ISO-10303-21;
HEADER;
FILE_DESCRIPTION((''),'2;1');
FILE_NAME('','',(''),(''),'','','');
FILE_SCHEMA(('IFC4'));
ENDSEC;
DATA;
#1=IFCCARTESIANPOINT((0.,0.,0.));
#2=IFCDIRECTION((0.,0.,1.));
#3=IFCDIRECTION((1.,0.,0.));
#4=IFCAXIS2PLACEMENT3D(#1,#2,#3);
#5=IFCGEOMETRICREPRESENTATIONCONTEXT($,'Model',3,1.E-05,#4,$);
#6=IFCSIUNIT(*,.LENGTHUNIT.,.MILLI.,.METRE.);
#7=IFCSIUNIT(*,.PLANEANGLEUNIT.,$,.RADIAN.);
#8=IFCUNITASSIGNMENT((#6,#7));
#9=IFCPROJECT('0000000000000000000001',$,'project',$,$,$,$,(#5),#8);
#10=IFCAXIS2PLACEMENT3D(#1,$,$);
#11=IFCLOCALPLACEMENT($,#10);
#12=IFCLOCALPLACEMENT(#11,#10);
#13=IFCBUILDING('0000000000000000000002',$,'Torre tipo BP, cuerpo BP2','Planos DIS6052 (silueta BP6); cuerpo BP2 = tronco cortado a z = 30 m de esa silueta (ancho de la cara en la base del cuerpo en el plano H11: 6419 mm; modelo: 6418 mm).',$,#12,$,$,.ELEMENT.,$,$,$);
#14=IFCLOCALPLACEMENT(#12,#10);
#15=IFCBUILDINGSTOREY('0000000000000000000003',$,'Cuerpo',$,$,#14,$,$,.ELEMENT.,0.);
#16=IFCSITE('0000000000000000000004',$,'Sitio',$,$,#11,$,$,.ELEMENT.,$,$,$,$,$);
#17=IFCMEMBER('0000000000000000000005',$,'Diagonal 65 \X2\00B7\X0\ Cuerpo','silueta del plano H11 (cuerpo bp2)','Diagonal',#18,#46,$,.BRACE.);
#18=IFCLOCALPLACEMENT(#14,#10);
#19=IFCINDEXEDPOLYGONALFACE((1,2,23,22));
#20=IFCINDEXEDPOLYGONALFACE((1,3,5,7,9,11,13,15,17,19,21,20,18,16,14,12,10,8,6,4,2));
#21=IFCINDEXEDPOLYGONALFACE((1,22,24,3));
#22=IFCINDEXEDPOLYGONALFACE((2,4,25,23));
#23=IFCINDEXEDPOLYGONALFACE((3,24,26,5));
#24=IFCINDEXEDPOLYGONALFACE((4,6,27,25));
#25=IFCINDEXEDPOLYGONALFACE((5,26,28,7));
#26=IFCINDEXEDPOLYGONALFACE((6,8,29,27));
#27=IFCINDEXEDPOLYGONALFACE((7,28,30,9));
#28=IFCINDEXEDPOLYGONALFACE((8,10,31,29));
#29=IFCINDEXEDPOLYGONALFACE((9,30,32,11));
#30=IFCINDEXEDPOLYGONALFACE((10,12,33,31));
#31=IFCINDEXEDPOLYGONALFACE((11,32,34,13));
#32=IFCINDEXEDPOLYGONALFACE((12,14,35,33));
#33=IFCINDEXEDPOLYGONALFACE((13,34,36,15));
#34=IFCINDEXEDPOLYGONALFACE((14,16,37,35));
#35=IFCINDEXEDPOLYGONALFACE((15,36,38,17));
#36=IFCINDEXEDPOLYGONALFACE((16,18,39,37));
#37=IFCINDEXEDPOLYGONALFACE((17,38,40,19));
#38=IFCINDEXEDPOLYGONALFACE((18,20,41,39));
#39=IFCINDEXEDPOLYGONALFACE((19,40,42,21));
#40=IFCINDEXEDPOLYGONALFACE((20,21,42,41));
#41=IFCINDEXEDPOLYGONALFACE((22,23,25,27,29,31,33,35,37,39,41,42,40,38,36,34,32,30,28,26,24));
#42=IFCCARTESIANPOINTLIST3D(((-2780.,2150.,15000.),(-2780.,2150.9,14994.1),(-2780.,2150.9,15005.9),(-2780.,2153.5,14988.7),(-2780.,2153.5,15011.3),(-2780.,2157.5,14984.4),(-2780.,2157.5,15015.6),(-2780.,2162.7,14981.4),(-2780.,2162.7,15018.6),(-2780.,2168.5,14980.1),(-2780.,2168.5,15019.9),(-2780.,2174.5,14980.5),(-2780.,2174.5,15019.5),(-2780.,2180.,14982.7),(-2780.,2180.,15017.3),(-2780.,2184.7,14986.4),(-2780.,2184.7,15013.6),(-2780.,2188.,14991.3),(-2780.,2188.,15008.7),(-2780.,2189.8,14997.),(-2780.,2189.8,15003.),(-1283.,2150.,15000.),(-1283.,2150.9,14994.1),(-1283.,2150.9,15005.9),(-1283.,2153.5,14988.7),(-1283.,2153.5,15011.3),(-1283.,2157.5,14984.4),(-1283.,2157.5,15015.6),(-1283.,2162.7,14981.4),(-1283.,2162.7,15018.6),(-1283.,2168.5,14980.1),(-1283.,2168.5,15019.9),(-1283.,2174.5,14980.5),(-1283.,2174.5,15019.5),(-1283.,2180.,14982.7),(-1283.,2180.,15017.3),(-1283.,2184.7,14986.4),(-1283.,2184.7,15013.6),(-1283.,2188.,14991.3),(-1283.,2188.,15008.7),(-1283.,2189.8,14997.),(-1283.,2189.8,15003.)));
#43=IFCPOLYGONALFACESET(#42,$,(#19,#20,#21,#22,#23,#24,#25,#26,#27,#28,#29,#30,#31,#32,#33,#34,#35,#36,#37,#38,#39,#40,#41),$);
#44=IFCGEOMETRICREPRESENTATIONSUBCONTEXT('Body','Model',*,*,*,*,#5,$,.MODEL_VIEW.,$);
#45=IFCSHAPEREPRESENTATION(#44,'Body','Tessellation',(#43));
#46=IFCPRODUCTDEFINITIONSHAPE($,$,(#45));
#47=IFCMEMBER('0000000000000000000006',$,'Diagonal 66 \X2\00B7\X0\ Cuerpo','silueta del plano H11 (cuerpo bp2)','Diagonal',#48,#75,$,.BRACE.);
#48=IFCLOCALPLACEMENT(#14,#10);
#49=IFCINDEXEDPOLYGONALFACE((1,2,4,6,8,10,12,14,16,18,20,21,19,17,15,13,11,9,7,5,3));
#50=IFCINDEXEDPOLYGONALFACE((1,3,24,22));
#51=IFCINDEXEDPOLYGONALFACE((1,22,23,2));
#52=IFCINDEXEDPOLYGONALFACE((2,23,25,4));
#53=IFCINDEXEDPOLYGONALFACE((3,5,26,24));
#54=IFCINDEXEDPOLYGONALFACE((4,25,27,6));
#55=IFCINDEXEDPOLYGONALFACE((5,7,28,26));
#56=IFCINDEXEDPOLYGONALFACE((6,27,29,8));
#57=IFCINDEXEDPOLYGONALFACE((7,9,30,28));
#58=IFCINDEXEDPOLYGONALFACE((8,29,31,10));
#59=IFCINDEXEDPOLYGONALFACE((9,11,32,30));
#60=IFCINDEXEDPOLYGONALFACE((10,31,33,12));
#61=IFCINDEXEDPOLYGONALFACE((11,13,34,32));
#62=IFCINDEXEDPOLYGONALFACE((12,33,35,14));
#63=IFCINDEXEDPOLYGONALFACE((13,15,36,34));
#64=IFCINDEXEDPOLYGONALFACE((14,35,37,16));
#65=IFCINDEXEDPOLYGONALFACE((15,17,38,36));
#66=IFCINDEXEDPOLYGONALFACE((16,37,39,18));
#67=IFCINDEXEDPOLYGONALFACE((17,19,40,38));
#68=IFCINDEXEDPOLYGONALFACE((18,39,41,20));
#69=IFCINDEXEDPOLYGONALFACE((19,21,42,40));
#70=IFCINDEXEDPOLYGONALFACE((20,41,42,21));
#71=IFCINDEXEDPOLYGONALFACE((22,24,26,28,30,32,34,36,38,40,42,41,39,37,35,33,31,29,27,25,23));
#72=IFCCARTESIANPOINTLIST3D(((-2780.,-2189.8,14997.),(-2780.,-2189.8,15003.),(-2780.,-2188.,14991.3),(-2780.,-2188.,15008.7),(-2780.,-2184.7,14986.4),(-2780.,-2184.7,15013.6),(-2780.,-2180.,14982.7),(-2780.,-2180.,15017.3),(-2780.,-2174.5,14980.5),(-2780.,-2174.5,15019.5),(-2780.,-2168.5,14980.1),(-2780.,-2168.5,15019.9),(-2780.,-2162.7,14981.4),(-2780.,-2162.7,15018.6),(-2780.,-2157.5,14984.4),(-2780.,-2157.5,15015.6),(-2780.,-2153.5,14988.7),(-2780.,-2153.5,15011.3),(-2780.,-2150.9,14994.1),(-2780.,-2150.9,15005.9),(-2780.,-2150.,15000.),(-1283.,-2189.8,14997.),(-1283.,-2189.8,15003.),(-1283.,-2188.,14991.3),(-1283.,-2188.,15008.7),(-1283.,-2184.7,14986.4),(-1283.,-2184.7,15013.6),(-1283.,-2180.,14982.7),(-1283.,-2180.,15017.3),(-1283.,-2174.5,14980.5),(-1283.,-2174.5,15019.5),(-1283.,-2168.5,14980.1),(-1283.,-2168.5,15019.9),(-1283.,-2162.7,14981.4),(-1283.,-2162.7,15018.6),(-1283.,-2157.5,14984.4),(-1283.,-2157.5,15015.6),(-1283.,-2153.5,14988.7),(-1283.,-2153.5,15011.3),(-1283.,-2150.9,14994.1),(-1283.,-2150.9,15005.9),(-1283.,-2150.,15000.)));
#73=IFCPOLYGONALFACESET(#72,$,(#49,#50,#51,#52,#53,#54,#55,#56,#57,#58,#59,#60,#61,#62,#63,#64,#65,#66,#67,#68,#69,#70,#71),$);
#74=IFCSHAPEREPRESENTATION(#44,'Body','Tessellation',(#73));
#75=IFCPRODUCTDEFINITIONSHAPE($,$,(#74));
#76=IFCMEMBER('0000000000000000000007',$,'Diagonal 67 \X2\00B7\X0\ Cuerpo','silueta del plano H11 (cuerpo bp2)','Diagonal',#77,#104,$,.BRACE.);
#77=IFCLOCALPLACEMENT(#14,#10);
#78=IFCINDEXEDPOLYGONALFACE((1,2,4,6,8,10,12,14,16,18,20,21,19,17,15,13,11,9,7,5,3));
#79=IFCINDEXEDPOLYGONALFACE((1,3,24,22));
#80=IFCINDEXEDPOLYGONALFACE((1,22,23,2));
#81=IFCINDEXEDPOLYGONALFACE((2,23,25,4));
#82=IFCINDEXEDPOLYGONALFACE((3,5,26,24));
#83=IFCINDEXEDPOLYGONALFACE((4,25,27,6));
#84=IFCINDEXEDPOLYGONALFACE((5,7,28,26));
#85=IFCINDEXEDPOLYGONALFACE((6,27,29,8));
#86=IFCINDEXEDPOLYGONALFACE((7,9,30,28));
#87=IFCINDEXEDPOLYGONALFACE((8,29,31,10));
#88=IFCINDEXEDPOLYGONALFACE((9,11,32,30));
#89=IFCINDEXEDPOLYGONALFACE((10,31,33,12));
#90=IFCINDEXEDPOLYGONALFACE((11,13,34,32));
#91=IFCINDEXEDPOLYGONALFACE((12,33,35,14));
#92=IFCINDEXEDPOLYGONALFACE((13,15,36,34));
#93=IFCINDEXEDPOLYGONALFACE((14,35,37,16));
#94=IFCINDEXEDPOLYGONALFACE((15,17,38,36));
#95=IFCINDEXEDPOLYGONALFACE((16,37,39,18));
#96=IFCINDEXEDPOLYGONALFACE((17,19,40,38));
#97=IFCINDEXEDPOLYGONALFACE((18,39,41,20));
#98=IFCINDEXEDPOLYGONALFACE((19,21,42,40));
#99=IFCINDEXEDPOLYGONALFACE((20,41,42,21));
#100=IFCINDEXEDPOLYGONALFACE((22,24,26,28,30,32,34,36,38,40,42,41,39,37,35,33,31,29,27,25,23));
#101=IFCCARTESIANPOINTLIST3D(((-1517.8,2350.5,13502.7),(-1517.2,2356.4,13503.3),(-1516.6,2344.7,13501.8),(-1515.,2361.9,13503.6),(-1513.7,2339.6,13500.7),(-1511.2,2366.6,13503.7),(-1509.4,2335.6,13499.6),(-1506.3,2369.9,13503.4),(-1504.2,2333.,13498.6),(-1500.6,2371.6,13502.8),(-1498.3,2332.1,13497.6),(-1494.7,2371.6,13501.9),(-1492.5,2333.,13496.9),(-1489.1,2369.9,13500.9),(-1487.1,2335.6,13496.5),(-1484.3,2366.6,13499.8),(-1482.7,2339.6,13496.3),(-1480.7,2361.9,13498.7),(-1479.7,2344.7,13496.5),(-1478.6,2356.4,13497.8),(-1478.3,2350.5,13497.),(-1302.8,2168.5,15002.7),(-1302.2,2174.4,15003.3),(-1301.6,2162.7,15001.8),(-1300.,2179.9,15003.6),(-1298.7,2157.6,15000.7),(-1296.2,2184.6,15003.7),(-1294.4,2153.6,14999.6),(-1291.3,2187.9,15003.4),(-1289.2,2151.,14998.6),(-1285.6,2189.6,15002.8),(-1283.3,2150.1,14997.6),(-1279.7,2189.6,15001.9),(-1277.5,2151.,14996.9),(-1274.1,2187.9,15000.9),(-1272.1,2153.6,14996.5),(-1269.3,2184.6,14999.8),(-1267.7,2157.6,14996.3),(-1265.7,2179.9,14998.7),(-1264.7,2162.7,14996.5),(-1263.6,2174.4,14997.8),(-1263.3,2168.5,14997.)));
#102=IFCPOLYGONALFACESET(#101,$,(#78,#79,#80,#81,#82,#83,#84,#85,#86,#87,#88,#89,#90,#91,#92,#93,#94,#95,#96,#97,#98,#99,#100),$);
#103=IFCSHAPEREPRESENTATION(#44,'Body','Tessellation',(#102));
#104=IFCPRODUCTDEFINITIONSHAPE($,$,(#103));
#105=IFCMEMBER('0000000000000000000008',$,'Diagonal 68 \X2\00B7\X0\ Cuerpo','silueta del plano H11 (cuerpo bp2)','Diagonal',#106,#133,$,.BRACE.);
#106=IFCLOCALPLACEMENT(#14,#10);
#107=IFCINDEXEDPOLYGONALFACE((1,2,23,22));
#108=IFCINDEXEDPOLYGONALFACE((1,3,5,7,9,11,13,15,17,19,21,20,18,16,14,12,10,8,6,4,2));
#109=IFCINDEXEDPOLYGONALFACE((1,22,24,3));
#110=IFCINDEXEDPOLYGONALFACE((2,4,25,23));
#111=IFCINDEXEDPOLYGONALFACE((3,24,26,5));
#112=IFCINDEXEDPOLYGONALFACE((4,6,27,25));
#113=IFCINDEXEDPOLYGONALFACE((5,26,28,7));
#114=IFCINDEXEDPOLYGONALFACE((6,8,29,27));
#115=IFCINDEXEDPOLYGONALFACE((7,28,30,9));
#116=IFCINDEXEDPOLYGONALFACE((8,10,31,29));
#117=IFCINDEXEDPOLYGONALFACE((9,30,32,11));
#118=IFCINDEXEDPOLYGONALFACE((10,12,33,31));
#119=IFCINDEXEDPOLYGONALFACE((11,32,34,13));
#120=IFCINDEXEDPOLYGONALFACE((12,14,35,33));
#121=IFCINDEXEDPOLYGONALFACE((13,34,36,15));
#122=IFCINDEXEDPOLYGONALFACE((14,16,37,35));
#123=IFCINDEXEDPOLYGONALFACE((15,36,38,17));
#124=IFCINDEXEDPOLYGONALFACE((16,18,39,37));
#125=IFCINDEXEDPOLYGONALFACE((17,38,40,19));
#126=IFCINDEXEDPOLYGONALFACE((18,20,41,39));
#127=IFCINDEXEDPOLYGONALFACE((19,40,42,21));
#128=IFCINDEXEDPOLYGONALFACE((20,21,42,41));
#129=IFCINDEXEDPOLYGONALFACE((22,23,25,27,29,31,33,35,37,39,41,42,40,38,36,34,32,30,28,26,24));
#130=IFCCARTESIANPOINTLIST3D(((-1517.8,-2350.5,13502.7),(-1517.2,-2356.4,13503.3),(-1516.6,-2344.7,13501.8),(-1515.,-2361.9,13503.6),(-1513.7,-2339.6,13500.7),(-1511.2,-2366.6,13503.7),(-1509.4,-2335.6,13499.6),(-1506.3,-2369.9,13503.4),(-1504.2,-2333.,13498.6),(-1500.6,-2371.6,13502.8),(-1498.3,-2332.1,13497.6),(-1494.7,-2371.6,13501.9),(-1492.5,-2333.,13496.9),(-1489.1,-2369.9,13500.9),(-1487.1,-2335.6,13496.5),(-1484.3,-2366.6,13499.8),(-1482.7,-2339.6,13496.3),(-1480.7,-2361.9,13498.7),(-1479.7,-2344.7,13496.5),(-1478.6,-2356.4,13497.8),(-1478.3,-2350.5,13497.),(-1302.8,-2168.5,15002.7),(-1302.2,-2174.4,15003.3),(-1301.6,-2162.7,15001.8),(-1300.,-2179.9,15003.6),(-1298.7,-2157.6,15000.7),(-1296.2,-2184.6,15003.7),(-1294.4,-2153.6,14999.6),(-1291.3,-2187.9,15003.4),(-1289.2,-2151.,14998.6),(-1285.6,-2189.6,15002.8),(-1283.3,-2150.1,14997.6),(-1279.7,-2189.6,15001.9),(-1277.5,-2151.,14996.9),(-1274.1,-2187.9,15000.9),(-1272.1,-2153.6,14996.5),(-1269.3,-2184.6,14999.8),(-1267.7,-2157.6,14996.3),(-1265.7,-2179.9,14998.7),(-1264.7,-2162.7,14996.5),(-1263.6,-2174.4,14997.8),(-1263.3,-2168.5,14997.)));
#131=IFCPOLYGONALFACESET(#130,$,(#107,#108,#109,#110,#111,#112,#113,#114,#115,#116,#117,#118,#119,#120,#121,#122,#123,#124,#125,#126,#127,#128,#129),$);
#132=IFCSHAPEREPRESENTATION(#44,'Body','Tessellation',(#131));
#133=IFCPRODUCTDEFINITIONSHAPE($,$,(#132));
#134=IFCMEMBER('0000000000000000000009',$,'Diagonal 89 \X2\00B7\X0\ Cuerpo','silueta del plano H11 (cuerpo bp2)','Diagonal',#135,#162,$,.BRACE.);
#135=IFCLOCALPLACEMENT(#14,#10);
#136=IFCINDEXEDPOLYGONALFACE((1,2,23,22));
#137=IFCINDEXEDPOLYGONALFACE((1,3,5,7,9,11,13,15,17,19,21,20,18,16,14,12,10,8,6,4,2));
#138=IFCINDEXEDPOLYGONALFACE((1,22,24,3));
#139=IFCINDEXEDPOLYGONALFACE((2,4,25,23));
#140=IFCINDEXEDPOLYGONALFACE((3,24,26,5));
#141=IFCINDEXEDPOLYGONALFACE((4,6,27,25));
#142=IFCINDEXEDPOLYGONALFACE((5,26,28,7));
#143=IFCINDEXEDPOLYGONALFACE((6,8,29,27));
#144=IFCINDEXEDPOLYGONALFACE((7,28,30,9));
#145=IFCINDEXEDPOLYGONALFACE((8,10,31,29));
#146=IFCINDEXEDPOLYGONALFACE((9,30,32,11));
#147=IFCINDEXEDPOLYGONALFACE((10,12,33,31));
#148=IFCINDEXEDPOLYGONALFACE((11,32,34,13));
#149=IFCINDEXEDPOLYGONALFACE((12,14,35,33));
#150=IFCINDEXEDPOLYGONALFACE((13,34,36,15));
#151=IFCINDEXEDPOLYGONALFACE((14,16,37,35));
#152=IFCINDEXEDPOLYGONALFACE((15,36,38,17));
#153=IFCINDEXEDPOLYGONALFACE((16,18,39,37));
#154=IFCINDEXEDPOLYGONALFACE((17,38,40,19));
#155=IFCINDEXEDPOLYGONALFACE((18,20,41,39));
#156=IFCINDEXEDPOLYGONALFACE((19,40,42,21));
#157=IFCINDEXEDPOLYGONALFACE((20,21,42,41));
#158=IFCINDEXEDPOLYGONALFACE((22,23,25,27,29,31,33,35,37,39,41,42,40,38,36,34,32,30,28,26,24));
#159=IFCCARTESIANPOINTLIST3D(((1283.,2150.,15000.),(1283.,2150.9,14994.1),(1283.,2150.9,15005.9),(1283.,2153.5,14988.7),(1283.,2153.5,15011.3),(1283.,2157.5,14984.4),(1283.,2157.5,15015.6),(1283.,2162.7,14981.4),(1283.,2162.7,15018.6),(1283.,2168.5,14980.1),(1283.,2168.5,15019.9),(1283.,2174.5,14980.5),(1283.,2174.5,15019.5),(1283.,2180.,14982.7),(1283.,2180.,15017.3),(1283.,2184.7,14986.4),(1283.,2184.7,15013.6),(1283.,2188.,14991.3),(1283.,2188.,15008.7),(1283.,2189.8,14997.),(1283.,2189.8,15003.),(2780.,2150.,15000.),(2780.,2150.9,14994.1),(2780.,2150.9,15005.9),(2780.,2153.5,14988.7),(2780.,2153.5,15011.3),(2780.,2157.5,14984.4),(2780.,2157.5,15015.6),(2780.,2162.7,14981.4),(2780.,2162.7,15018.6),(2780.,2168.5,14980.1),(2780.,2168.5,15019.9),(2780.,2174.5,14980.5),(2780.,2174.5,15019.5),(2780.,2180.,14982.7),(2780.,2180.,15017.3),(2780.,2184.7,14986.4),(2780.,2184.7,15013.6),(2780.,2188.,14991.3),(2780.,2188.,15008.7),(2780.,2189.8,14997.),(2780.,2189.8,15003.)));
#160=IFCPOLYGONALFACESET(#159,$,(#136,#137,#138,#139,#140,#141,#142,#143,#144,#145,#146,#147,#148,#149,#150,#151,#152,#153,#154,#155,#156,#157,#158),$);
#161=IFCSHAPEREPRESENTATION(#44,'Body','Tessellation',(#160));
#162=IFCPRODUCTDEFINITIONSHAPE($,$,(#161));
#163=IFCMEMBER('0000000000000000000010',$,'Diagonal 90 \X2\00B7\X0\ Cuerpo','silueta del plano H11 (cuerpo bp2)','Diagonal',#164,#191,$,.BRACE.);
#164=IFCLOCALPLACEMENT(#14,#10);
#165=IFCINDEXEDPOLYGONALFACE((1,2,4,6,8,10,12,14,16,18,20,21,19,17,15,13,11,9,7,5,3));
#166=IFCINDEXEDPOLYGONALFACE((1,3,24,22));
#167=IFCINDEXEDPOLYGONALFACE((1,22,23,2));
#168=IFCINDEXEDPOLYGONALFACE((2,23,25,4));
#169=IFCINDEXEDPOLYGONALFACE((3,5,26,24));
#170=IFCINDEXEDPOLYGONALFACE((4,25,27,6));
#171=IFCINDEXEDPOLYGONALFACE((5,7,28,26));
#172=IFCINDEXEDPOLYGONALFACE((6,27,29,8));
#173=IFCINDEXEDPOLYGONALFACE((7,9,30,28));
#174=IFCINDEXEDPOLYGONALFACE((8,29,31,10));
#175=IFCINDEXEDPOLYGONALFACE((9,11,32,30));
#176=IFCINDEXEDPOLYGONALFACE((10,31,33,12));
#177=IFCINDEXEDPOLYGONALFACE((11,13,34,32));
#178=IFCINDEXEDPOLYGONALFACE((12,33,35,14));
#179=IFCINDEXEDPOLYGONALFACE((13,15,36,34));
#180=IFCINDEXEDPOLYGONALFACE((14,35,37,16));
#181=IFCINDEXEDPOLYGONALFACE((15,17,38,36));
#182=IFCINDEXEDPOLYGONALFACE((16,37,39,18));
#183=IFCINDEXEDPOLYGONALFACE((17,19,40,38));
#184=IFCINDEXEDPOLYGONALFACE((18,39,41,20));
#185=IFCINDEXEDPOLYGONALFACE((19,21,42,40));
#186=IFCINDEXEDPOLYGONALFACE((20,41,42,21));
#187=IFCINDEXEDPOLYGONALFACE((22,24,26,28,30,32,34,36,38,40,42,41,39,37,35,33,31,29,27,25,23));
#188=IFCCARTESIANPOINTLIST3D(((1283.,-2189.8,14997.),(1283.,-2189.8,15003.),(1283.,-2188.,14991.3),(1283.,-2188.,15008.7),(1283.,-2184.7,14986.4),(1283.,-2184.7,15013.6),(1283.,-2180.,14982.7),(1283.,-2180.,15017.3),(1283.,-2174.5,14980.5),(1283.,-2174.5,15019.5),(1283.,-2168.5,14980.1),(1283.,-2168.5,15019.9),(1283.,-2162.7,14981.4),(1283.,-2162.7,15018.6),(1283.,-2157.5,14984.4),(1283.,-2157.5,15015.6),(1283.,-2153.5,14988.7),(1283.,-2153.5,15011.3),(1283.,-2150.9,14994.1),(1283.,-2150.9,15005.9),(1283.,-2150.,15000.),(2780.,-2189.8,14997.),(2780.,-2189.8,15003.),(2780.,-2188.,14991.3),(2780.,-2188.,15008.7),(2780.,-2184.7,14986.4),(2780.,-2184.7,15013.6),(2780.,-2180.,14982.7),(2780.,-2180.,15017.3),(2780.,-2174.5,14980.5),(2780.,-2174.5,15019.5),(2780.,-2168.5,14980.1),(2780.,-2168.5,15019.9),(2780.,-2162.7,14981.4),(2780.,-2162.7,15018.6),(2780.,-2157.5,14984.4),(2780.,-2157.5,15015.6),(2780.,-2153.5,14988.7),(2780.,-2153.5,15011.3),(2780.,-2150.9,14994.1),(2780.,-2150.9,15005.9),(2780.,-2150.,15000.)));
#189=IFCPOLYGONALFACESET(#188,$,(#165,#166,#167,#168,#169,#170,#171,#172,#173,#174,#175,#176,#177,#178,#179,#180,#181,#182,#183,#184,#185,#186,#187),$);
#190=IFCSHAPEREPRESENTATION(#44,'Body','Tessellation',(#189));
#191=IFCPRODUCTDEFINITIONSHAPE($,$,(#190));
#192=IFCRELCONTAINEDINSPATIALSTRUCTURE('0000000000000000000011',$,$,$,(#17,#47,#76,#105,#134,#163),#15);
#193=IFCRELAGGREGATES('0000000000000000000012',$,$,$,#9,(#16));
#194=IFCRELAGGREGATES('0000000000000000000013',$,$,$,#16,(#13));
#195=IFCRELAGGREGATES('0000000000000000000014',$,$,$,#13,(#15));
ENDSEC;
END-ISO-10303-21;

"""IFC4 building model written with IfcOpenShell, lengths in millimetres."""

from ifc_helpers import new_model, si_unit, frame, origin, origin_with_axes, place, context, subcontext, project, spatial, circle, extrude, element, save


model = new_model("IFC4")

# Units and contexts
model_context = context("Model", 3, precision=1e-05, world=origin_with_axes())
body_context = subcontext(model_context, "Body", "Model", "MODEL_VIEW")
ifc_project = project(units=[si_unit("LENGTHUNIT", "METRE", prefix="MILLI"), si_unit("PLANEANGLEUNIT", "RADIAN")], contexts=[model_context])

# Site, building, storey
site_placement = place(None, origin())
site = spatial("IfcSite", under=ifc_project, at=site_placement, Name="Sitio", CompositionType="ELEMENT")
building_placement = place(site_placement, origin())
building = spatial("IfcBuilding", under=site, at=building_placement, Name="Torre tipo BP, cuerpo BP2", Description="Planos DIS6052 (silueta BP6); cuerpo BP2 = tronco cortado a z = 30 m de esa silueta (ancho de la cara en la base del cuerpo en el plano H11: 6419 mm; modelo: 6418 mm).", CompositionType="ELEMENT")
storey_placement = place(building_placement, origin())
storey = spatial("IfcBuildingStorey", under=building, at=storey_placement, Name="Cuerpo", CompositionType="ELEMENT", Elevation=0.0)

# Members
for number, where, z_axis, x_axis, name in (
    (1, (-2780.0, 2170.0, 15000.0), (1.0, 0.0, 0.0), (0.0, -1.0, 0.0), "Diagonal 65 · Cuerpo"),
    (2, (-2780.0, -2170.0, 15000.0), (1.0, 0.0, 0.0), (0.0, 1.0, 0.0), "Diagonal 66 · Cuerpo"),
):
    element("IfcMember", number, at=place(storey_placement, frame(where, z_axis=z_axis, x_axis=x_axis)), inside=storey, Name=name, Description="silueta del plano H11 (cuerpo bp2)", ObjectType="Diagonal", PredefinedType="BRACE", context=body_context, shape_type="SweptSolid", body=[
        extrude(circle(Radius=20.0), None, (0.0, 0.0, 1.0), 1497.0),
    ])
for number, where, z_axis, x_axis, name in (
    (3, (-1283.0, 2170.0, 15000.0), (-0.140871, 0.119249, -0.98282), (-0.016919, -0.992864, -0.118042), "Diagonal 67 · Cuerpo"),
    (4, (-1283.0, -2170.0, 15000.0), (-0.140871, -0.119249, -0.98282), (-0.016919, 0.992864, -0.118042), "Diagonal 68 · Cuerpo"),
):
    element("IfcMember", number, at=place(storey_placement, frame(where, z_axis=z_axis, x_axis=x_axis)), inside=storey, Name=name, Description="silueta del plano H11 (cuerpo bp2)", ObjectType="Diagonal", PredefinedType="BRACE", context=body_context, shape_type="SweptSolid", body=[
        extrude(circle(Radius=20.0), None, (0.0, 0.0, 1.0), 1526.2),
    ])
for number, where, z_axis, x_axis, name in (
    (5, (2780.0, 2170.0, 15000.0), (-1.0, 0.0, 0.0), (0.0, -1.0, 0.0), "Diagonal 89 · Cuerpo"),
    (6, (2780.0, -2170.0, 15000.0), (-1.0, 0.0, 0.0), (0.0, 1.0, 0.0), "Diagonal 90 · Cuerpo"),
):
    element("IfcMember", number, at=place(storey_placement, frame(where, z_axis=z_axis, x_axis=x_axis)), inside=storey, Name=name, Description="silueta del plano H11 (cuerpo bp2)", ObjectType="Diagonal", PredefinedType="BRACE", context=body_context, shape_type="SweptSolid", body=[
        extrude(circle(Radius=20.0), None, (0.0, 0.0, 1.0), 1497.0),
    ])

save(model, "model.ifc")
